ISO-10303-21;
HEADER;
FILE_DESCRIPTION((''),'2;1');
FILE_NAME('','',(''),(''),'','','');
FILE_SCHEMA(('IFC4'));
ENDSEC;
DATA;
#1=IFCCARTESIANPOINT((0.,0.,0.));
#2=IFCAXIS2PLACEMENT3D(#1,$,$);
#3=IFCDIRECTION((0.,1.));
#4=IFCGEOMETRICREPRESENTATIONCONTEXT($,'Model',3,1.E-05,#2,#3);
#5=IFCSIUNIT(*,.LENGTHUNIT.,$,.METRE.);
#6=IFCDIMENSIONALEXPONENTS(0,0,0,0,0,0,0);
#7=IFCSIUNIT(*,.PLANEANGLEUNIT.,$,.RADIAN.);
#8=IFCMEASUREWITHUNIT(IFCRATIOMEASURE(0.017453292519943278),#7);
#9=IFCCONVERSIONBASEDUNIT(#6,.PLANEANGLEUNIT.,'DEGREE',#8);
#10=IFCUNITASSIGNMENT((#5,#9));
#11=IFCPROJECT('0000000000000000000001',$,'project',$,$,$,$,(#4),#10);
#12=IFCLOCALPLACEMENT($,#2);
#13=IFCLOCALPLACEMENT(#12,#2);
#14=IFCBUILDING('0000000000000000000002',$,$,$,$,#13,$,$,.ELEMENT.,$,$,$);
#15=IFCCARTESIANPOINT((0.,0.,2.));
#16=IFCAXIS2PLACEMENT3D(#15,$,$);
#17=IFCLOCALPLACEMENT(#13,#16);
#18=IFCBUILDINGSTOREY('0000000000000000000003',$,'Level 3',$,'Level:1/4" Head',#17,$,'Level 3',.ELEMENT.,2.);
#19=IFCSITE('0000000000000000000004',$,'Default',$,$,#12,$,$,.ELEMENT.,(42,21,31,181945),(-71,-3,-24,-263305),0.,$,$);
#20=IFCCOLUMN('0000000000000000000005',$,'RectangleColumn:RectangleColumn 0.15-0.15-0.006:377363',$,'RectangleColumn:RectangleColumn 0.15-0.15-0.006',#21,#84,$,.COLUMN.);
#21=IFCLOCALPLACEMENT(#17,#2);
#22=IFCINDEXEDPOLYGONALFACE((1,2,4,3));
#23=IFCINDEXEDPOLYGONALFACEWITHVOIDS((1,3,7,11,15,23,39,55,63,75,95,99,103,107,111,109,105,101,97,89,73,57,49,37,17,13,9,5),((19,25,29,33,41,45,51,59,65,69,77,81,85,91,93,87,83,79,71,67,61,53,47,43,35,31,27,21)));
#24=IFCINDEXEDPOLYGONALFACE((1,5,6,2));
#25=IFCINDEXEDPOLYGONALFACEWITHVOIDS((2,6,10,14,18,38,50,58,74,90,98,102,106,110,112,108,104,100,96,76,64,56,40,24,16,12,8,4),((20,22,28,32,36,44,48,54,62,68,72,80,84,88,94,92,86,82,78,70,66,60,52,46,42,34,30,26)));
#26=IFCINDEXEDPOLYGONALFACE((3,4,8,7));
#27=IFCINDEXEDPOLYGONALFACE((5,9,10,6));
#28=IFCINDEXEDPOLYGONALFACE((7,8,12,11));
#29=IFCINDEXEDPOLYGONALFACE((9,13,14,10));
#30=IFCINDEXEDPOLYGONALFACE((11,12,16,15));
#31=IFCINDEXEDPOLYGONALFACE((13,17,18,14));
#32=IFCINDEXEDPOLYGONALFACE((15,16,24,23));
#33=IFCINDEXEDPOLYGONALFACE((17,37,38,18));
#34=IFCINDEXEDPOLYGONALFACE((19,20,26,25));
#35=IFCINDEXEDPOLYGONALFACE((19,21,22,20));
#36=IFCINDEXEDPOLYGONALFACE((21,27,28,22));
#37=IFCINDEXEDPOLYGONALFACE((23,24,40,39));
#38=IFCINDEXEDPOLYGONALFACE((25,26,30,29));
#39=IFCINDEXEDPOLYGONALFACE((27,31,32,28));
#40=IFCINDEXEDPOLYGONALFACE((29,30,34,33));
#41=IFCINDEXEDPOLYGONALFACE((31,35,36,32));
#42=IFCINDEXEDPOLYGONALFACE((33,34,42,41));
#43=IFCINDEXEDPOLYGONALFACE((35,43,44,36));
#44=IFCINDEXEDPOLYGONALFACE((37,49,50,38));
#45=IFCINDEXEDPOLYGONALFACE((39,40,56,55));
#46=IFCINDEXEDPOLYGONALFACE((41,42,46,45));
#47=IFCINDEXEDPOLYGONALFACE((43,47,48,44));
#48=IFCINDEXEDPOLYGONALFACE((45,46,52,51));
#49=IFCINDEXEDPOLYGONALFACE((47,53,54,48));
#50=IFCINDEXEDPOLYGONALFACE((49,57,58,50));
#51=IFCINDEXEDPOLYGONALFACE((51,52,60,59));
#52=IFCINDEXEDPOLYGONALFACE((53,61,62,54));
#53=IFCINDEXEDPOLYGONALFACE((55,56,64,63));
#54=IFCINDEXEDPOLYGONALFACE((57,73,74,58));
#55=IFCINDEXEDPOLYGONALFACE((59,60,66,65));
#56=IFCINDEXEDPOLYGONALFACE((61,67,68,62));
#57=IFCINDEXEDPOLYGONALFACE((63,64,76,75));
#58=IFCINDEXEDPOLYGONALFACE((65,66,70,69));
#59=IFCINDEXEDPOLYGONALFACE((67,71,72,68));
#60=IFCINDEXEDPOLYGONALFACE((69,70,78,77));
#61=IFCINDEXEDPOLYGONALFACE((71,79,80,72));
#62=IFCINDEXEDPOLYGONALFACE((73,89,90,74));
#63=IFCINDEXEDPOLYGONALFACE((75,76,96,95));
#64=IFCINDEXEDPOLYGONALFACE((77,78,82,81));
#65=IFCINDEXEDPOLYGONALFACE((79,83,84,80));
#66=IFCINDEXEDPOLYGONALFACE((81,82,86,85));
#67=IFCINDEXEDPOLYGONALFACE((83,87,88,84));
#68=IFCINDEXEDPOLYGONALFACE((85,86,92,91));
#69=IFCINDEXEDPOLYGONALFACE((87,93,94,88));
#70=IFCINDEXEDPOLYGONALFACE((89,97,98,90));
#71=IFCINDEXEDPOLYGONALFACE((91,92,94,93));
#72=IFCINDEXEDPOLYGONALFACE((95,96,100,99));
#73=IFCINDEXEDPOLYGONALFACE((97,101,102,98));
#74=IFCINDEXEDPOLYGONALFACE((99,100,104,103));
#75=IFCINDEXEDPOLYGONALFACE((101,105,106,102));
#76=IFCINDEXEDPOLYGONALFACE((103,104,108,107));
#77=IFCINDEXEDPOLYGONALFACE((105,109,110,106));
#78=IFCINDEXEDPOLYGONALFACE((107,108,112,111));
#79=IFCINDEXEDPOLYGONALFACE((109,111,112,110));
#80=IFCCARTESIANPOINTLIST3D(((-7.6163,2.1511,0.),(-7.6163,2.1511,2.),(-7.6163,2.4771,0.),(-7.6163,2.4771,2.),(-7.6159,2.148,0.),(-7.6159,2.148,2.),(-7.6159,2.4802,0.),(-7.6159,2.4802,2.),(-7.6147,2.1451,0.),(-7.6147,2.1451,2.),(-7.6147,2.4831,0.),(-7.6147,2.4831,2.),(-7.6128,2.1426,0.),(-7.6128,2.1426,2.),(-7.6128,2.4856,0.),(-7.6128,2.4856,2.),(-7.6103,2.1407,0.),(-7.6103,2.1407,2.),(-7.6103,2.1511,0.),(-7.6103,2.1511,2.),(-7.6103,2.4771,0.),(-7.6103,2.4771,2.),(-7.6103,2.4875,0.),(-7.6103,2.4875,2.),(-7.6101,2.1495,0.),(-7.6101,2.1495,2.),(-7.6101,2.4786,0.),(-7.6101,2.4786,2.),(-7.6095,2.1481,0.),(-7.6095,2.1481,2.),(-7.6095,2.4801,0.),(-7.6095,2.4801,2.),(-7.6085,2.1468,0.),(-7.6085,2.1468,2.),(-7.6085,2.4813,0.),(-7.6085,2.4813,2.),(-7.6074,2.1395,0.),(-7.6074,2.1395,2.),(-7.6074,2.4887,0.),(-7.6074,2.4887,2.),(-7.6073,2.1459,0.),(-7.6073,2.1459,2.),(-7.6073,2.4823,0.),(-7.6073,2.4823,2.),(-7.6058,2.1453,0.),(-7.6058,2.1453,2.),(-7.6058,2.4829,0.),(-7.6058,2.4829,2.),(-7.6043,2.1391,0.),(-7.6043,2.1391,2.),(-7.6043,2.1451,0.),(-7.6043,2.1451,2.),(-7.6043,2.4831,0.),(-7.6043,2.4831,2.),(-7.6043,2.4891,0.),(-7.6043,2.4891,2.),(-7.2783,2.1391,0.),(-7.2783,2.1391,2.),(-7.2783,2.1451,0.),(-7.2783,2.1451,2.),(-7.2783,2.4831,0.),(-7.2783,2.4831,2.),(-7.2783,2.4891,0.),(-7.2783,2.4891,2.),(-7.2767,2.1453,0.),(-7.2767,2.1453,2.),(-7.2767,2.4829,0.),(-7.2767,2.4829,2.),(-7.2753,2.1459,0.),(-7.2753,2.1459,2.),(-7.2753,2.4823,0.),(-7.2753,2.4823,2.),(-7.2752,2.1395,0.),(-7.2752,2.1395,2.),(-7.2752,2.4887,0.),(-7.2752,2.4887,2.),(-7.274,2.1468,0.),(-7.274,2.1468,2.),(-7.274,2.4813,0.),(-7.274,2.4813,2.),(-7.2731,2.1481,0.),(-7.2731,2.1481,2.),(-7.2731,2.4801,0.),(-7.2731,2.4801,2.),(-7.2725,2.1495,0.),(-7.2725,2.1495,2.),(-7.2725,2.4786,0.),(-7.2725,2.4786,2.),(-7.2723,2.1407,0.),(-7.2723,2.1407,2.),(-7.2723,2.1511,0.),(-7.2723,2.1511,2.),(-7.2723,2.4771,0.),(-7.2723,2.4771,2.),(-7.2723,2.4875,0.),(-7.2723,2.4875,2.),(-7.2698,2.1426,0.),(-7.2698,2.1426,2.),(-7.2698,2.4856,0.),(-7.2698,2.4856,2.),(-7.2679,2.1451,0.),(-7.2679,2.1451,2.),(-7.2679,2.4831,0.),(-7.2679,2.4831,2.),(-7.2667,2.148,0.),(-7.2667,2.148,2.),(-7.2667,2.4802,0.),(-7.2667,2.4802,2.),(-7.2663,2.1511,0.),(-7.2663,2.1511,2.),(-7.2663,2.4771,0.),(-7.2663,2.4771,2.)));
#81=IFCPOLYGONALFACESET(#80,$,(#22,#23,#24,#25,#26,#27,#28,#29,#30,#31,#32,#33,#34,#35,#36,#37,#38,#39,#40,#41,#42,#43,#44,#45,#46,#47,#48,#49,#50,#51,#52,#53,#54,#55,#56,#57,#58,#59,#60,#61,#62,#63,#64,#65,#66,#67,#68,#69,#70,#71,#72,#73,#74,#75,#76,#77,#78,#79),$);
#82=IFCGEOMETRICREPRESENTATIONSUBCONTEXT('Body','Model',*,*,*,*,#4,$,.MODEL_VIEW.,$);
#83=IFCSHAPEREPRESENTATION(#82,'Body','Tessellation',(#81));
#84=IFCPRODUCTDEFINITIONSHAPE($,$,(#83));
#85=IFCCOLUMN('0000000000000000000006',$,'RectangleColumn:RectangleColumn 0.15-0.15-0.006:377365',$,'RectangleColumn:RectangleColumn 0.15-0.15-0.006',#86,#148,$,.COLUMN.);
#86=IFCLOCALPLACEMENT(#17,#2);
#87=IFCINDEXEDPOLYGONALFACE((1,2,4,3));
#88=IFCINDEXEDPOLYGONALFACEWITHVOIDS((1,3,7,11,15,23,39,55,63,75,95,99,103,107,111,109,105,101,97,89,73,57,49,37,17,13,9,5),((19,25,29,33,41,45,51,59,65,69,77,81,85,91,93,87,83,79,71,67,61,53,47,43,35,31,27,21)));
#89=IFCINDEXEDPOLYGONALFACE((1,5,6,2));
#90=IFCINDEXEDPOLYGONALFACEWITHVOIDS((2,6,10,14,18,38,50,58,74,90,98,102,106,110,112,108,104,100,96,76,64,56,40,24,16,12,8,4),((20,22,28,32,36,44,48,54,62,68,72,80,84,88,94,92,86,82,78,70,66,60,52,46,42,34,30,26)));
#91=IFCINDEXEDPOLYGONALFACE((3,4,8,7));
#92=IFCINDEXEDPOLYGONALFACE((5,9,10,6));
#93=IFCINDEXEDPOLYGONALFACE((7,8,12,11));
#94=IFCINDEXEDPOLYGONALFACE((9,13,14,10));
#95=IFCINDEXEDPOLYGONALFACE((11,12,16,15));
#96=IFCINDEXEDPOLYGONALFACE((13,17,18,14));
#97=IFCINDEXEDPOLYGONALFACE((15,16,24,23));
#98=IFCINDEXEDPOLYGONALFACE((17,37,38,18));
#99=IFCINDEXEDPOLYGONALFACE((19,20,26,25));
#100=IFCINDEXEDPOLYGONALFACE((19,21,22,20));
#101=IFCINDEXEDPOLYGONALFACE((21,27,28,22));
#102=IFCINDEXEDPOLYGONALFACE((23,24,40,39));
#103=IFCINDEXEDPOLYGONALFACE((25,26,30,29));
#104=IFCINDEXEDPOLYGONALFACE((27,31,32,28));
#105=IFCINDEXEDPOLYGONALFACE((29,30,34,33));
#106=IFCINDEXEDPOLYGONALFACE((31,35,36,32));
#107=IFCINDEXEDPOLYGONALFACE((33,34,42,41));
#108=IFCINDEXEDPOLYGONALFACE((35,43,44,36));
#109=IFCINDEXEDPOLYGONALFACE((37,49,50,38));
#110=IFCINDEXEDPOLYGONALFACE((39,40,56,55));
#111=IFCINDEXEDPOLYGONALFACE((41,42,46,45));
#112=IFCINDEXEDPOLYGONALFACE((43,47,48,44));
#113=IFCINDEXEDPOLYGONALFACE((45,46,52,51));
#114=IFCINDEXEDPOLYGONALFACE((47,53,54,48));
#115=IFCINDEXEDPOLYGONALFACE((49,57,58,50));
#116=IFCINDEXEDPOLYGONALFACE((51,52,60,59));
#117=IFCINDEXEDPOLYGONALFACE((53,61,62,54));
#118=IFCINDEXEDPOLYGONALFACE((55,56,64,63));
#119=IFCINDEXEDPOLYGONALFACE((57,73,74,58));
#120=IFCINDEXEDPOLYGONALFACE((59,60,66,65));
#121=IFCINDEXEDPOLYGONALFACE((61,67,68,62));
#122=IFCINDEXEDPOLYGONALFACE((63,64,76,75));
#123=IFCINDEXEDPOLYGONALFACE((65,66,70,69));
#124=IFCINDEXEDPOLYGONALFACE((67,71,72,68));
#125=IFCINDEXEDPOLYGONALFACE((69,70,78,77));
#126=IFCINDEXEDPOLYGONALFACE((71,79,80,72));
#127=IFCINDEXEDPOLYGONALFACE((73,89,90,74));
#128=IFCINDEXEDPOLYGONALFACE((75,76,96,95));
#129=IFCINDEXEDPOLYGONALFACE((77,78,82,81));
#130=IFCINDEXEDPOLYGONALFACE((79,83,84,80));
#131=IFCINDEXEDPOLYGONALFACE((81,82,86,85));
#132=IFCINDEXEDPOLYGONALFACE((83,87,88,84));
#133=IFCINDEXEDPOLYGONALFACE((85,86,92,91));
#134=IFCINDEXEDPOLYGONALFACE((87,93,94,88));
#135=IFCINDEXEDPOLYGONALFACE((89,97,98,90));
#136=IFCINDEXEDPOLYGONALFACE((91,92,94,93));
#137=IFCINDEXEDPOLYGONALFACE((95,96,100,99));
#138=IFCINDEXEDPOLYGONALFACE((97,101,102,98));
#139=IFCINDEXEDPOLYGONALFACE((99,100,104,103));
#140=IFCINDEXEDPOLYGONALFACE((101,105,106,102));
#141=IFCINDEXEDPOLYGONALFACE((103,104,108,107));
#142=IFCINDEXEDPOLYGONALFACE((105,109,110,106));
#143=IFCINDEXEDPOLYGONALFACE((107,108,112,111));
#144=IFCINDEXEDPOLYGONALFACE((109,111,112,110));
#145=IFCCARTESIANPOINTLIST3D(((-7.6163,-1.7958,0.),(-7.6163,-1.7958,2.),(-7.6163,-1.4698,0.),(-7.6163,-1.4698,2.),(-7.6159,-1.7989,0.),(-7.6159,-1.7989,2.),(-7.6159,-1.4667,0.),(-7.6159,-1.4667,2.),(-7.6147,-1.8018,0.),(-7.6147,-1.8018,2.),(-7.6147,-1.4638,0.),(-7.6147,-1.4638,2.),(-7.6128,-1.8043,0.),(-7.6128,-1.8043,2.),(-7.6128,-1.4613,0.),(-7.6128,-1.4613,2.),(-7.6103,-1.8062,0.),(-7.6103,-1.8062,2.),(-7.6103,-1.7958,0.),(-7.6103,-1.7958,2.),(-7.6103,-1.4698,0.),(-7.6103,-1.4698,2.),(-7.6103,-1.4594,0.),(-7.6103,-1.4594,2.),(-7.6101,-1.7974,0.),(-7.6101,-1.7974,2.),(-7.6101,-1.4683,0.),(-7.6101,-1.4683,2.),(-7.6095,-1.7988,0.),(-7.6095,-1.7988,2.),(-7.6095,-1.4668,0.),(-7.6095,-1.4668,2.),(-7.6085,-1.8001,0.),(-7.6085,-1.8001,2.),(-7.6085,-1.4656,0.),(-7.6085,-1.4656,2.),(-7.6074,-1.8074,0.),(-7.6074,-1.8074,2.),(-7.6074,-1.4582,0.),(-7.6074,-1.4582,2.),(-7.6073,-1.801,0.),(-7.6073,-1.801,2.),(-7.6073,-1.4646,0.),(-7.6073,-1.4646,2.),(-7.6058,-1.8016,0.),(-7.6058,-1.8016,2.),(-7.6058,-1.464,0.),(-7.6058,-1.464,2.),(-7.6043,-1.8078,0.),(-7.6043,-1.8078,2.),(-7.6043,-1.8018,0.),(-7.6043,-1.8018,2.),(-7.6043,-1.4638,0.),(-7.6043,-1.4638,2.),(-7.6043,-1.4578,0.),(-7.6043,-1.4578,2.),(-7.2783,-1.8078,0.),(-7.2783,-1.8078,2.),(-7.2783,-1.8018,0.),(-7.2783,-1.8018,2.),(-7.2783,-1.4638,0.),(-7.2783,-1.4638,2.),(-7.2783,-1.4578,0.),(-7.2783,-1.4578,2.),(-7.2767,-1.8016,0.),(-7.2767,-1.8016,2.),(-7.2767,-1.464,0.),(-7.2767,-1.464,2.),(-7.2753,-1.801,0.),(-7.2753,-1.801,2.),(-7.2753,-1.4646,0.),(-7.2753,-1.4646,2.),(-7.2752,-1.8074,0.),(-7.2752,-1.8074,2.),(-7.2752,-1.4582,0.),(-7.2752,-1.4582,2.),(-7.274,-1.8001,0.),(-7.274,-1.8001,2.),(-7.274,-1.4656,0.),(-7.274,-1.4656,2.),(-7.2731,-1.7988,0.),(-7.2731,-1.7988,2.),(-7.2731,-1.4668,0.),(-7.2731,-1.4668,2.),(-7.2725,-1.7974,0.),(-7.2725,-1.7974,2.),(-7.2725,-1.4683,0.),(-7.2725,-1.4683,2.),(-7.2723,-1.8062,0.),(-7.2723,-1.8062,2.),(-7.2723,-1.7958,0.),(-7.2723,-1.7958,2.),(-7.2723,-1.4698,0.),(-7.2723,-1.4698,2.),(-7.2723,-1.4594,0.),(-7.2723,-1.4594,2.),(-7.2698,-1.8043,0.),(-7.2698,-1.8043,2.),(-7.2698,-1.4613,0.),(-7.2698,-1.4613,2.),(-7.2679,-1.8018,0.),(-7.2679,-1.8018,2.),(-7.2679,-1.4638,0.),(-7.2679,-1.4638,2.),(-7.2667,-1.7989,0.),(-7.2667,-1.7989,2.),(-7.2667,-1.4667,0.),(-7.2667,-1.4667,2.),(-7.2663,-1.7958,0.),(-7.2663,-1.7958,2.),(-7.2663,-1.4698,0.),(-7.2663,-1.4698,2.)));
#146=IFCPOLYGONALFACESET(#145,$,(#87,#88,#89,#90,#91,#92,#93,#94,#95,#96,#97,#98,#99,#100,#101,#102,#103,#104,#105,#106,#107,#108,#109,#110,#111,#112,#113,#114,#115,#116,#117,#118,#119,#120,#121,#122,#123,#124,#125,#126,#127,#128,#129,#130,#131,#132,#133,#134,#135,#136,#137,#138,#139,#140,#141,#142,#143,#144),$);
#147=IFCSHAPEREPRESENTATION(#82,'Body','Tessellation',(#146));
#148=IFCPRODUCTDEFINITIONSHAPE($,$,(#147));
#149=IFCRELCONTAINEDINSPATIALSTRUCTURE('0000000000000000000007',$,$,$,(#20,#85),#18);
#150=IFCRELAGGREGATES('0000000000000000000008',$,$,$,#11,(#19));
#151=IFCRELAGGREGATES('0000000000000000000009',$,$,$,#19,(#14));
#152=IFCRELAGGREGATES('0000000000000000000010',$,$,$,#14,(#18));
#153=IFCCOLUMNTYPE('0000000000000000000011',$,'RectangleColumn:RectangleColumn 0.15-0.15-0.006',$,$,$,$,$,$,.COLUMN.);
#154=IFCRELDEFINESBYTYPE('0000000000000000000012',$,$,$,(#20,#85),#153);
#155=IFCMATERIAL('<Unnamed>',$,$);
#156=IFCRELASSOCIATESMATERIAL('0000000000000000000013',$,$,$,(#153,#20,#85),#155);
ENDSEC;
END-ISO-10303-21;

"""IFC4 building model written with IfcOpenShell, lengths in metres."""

from ifc_helpers import new_model, entity, si_unit, converted_unit, direction, frame, origin, place, context, subcontext, project, spatial, line, arc, indexed_curve, outline, extrude, source, transform, mapped, material, type_object, type_shapes, element, save


model = new_model("IFC4")

# Units and contexts
model_context = context("Model", 3, precision=1e-05, world=origin(), true_north=direction((0.0, 1.0)))
body_context = subcontext(model_context, "Body", "Model", "MODEL_VIEW")
ifc_project = project(units=[si_unit("LENGTHUNIT", "METRE"), converted_unit("PLANEANGLEUNIT", "DEGREE", entity("IfcRatioMeasure", 0.017453292519943278), si_unit("PLANEANGLEUNIT", "RADIAN"), dimensions=[0, 0, 0, 0, 0, 0, 0])], contexts=[model_context])

# Site, building, storey
site_placement = place(None, origin())
site = spatial("IfcSite", under=ifc_project, at=site_placement, Name="Default", CompositionType="ELEMENT", RefLatitude=(42, 21, 31, 181945), RefLongitude=(-71, -3, -24, -263305), RefElevation=0.0)
building_placement = place(site_placement, origin())
building = spatial("IfcBuilding", under=site, at=building_placement, CompositionType="ELEMENT")
storey_placement = place(building_placement, frame((0.0, 0.0, 2.0)))
storey = spatial("IfcBuildingStorey", under=building, at=storey_placement, Name="Level 3", ObjectType="Level:1/4\" Head", LongName="Level 3", CompositionType="ELEMENT", Elevation=2.0)

# Columns
ifc_material_1 = material(Name="<Unnamed>")
column_type = type_object("IfcColumnType", Name="RectangleColumn:RectangleColumn 0.15-0.15-0.006", PredefinedType="COLUMN", material=ifc_material_1)
shared_shape = source(origin(), body_context, "Body", "SweptSolid", [
    extrude(outline(indexed_curve([(-0.163, -0.175), (0.163, -0.175), (0.1715, -0.1715), (0.175, -0.163), (0.175, 0.163), (0.1715, 0.1715), (0.163, 0.175), (-0.163, 0.175), (-0.1715, 0.1715), (-0.175, 0.163), (-0.175, -0.163), (-0.1715, -0.1715)], segments=[line(1, 2), arc(2, 3, 4), line(4, 5), arc(5, 6, 7), line(7, 8), arc(8, 9, 10), line(10, 11), arc(11, 12, 1)], self_intersect=False), holes=[indexed_curve([(-0.163, -0.169), (-0.1672, -0.1672), (-0.169, -0.163), (-0.169, 0.163), (-0.1672, 0.1672), (-0.163, 0.169), (0.163, 0.169), (0.1672, 0.1672), (0.169, 0.163), (0.169, -0.163), (0.1672, -0.1672), (0.163, -0.169)], segments=[arc(1, 2, 3), line(3, 4), arc(4, 5, 6), line(6, 7), arc(7, 8, 9), line(9, 10), arc(10, 11, 12), line(12, 1)], self_intersect=False)]), frame((0.0, 0.0, 2.0), z_axis=(0.0, 0.0, 1.0), x_axis=(-1.0, 0.0, 0.0)), (0.0, 0.0, 1.0), 2.0),
])
type_shapes(column_type, [shared_shape])
for number, where, name in (
    (1, (-7.4413, 2.3141, -2.0), "RectangleColumn:RectangleColumn 0.15-0.15-0.006:377363"),
    (2, (-7.4413, -1.6328, -2.0), "RectangleColumn:RectangleColumn 0.15-0.15-0.006:377365"),
):
    element("IfcColumn", number, at=place(storey_placement, frame(where)), inside=storey, type_object=column_type, material=ifc_material_1, Name=name, ObjectType="RectangleColumn:RectangleColumn 0.15-0.15-0.006", PredefinedType="COLUMN", context=body_context, shape_type="MappedRepresentation", body=[
        mapped(shared_shape, transform((0.0, 0.0, 0.0), scale=1.0)),
    ])

save(model, "model.ifc")
